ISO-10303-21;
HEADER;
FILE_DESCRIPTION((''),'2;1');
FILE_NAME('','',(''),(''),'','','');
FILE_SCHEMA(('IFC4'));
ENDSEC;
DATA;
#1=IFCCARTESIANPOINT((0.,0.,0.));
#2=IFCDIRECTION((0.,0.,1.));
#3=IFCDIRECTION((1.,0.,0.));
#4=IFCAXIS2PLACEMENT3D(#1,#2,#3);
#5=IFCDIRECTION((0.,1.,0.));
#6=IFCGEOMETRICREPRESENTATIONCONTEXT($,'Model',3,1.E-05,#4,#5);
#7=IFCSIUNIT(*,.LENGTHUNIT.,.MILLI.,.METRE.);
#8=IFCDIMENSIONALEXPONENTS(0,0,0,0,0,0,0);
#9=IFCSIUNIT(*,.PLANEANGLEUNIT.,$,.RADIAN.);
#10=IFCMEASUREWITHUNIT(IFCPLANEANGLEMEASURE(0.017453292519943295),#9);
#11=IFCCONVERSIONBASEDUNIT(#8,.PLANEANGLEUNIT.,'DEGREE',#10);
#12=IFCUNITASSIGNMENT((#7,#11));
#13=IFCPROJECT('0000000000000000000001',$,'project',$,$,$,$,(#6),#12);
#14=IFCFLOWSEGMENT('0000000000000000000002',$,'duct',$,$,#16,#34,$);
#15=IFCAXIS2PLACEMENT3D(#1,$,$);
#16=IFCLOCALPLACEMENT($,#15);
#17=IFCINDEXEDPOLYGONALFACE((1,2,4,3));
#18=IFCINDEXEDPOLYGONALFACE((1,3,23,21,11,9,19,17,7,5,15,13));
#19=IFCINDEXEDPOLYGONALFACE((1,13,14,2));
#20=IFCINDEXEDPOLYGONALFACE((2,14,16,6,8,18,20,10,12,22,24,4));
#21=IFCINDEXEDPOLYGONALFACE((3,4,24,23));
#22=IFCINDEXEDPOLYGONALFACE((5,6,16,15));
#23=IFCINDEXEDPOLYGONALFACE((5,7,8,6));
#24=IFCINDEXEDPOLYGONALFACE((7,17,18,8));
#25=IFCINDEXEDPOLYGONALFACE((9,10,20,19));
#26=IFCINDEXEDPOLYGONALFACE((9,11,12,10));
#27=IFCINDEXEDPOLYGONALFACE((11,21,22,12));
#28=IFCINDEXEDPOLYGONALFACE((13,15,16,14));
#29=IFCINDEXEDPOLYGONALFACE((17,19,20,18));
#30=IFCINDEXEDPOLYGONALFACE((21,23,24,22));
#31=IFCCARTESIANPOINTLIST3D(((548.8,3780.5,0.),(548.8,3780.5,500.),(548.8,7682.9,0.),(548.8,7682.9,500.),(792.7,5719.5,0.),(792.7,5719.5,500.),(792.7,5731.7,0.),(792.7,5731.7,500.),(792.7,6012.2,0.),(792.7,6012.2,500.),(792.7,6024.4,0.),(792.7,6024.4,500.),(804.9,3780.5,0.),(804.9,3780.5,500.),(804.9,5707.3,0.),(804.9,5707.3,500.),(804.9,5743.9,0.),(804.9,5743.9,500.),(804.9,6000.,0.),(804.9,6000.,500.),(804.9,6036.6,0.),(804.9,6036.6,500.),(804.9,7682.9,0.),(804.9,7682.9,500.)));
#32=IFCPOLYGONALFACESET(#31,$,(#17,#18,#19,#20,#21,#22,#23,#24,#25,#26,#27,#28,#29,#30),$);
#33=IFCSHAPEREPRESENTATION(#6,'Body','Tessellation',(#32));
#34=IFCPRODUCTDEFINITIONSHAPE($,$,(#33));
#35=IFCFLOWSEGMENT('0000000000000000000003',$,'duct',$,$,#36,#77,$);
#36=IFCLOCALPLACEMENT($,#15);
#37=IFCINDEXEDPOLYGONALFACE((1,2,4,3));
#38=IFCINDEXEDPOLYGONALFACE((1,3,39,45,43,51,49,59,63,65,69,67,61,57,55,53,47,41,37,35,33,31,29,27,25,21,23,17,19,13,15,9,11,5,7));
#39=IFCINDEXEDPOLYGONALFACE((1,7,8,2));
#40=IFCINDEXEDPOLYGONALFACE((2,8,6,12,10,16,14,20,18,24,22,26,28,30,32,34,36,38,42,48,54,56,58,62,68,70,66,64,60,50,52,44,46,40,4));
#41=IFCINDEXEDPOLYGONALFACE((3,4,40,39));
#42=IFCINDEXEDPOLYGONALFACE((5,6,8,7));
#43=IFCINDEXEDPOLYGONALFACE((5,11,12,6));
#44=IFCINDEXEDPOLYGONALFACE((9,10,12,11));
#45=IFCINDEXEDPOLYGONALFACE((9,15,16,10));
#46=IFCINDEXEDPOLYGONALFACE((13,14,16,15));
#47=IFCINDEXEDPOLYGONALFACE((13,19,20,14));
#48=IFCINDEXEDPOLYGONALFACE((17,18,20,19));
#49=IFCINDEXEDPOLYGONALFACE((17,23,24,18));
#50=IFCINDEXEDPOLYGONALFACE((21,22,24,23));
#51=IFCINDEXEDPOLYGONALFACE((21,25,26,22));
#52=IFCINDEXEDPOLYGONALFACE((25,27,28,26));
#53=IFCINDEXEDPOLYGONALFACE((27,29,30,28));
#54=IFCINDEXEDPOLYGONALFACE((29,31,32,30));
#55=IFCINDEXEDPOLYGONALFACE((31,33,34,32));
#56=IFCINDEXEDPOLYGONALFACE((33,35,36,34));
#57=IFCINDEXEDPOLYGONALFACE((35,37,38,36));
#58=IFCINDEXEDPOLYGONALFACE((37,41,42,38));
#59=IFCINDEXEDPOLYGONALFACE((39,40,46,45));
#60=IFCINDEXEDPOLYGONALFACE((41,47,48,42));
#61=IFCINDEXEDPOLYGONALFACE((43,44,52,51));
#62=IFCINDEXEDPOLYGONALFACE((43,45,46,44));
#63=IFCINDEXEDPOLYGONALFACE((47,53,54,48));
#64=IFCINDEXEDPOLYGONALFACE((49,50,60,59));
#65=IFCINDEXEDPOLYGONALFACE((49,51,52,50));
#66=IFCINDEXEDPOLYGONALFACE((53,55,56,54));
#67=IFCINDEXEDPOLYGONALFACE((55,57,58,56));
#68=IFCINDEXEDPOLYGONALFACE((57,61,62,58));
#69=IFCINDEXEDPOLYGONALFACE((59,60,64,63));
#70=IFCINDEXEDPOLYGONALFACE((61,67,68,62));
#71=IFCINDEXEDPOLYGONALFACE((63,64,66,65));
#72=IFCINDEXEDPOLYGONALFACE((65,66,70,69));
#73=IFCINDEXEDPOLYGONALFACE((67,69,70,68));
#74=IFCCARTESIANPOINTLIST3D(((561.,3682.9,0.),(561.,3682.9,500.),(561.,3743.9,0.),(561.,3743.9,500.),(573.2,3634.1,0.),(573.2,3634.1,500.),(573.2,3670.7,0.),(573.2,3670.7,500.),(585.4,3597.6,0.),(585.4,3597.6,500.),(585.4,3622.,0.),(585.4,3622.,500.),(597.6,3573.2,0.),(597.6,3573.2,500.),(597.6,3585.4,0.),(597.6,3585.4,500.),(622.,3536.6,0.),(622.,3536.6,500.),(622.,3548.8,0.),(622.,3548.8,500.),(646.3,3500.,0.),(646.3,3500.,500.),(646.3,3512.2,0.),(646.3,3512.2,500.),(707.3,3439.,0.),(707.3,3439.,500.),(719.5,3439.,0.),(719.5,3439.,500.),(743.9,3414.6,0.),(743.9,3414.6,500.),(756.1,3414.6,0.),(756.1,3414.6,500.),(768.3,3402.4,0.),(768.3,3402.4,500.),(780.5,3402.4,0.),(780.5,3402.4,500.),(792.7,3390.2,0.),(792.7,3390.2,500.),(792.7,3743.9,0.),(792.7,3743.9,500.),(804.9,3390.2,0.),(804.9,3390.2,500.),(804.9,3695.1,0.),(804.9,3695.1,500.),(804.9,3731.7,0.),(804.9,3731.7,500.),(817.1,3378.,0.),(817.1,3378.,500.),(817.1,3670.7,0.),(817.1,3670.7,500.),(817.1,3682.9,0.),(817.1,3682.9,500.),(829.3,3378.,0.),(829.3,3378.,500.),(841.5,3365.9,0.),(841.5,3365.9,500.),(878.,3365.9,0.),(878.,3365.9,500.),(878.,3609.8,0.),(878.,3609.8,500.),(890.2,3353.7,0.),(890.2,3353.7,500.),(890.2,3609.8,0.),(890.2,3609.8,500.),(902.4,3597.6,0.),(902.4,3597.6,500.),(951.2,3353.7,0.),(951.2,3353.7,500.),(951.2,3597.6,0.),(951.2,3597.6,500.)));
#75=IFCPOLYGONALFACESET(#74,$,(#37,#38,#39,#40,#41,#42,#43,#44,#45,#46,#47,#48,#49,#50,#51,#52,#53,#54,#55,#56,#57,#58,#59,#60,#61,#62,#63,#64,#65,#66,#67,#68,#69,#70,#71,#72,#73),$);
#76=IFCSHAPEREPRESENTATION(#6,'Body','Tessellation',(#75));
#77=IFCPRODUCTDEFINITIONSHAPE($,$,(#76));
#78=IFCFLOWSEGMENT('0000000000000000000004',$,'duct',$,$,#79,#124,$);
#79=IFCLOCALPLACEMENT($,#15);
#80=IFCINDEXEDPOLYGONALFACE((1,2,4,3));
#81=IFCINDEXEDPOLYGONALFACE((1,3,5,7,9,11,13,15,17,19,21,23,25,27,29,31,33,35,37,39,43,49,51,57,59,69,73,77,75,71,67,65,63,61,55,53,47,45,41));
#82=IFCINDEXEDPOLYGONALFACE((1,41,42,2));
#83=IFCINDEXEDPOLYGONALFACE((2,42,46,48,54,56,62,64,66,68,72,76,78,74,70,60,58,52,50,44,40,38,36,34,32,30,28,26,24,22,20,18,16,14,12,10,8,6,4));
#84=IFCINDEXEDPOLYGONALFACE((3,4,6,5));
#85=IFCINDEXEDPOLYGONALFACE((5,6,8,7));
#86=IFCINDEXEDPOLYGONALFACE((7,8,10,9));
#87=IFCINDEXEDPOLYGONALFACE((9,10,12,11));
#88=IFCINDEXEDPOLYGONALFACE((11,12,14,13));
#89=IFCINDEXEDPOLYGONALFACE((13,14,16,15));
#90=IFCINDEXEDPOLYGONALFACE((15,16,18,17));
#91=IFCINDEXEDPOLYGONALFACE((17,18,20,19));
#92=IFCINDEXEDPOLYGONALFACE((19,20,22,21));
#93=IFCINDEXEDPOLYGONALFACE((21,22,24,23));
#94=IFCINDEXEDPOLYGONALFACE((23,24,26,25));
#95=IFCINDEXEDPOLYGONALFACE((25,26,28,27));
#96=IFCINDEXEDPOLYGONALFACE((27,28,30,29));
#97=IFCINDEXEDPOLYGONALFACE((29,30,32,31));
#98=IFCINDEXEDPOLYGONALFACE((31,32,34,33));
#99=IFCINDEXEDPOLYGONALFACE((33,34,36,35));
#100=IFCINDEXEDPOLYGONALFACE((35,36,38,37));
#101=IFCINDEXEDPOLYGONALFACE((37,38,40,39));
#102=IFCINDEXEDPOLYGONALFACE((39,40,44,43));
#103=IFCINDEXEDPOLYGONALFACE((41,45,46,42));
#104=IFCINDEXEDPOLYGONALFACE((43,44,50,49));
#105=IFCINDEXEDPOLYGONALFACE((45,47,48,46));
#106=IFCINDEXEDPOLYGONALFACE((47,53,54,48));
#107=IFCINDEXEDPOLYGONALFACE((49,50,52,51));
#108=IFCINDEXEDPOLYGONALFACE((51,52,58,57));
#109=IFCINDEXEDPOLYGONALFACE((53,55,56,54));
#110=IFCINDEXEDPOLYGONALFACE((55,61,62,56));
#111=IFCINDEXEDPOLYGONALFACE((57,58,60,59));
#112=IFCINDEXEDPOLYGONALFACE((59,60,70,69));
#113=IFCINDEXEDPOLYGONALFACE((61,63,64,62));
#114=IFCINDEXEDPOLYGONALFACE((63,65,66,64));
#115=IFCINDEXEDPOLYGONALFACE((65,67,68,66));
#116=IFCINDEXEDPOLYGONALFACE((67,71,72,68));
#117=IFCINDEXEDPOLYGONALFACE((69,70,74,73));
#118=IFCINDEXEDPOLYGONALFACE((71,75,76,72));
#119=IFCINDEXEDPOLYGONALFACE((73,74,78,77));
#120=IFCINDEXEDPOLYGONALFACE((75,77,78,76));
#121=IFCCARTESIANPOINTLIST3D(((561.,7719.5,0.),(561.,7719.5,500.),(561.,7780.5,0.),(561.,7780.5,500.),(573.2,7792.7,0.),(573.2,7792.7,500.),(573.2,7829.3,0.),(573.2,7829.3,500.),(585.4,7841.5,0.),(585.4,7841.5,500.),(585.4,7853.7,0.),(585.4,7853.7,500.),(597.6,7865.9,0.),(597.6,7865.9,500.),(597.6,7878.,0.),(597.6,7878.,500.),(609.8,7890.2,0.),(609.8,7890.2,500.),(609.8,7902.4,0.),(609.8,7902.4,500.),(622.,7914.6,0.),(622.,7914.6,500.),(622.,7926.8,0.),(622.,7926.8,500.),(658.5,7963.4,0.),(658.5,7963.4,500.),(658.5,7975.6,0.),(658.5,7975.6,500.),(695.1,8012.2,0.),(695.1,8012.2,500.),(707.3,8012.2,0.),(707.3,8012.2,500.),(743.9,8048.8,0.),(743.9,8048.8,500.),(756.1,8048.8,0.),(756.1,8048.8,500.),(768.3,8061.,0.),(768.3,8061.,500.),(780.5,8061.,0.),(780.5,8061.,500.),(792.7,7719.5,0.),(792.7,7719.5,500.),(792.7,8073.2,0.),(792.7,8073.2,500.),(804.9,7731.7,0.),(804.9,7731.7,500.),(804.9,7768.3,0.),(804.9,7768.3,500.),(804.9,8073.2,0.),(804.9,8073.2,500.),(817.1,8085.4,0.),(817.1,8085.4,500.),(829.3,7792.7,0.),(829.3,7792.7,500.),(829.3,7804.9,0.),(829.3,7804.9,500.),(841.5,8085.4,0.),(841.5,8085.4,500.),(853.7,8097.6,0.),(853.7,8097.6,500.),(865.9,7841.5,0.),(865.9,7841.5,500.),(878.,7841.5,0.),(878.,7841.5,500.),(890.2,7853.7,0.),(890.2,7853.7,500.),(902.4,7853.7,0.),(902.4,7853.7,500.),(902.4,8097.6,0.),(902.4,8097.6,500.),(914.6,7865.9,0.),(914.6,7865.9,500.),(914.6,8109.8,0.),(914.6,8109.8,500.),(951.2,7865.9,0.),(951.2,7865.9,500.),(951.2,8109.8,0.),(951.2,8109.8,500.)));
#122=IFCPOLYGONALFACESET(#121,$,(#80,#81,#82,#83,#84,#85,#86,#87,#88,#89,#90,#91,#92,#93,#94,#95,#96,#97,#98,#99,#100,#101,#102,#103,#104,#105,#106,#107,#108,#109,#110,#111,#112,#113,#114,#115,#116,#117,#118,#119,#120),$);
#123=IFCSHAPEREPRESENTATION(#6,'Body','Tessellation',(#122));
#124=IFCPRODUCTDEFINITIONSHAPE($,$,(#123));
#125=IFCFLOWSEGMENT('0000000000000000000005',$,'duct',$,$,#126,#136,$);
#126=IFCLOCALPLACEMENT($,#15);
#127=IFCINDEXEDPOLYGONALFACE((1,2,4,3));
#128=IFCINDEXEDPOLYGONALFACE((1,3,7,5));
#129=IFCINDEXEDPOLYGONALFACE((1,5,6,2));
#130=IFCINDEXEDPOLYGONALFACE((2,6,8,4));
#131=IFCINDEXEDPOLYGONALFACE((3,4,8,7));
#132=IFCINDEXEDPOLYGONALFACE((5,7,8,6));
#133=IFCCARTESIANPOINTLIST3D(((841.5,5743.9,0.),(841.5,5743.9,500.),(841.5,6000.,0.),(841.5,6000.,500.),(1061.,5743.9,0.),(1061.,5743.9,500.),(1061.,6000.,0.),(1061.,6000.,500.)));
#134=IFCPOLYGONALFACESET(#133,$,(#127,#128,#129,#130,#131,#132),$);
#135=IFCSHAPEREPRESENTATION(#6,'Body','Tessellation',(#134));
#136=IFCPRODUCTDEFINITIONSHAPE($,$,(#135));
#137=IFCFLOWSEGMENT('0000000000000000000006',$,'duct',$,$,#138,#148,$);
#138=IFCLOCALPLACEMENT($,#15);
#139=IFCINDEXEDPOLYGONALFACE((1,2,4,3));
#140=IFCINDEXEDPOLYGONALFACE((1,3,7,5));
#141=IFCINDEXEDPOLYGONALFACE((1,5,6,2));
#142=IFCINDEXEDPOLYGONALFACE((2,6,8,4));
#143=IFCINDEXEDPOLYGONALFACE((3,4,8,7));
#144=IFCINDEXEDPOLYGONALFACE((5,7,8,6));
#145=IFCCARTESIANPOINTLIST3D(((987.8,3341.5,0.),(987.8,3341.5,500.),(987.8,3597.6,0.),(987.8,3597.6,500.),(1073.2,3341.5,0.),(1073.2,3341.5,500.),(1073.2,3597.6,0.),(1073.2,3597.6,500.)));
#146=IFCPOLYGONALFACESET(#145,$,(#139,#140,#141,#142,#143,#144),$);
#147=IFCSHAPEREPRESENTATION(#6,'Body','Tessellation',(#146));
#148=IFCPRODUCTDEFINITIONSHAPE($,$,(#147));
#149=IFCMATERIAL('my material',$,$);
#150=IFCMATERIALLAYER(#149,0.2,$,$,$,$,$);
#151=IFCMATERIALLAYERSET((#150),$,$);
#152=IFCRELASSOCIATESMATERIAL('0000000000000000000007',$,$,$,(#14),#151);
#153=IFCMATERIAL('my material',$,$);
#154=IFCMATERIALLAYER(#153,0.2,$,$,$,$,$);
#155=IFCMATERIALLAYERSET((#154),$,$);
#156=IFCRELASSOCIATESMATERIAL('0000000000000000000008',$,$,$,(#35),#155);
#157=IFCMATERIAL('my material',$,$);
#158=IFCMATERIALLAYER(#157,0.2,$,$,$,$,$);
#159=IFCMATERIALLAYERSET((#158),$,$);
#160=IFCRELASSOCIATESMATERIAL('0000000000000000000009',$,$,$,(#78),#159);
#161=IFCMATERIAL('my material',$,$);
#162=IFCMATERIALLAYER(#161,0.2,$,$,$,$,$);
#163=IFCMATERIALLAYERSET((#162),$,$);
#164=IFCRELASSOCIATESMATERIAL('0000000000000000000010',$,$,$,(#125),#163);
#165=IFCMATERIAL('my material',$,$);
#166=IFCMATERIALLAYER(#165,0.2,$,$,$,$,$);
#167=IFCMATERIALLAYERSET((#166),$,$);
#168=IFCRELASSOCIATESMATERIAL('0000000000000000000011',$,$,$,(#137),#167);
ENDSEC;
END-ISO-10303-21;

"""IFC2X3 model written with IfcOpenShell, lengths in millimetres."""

from ifc_helpers import new_model, entity, si_unit, converted_unit, direction, origin_with_axes, place, context, project, polyline, outline, extrude, material, layer, layer_set, layer_usage, element, save


model = new_model("IFC2X3")

# Units and contexts
model_context = context("Model", 3, precision=1e-05, world=origin_with_axes(), true_north=direction((0.0, 1.0, 0.0)))
ifc_project = project(units=[si_unit("LENGTHUNIT", "METRE", prefix="MILLI"), converted_unit("PLANEANGLEUNIT", "DEGREE", entity("IfcPlaneAngleMeasure", 0.017453292519943295), si_unit("PLANEANGLEUNIT", "RADIAN"), dimensions=[0, 0, 0, 0, 0, 0, 0])], contexts=[model_context])

# Flow segments
ifc_material_1 = material(Name="my material")
ifc_layer_1 = layer(ifc_material_1, 0.2)
ifc_layer_set_1 = layer_set([ifc_layer_1])
ifc_layer_usage_1 = layer_usage(ifc_layer_set_1, "AXIS2", "POSITIVE", -0.1)
flow_segment_1_placement = place(None, origin_with_axes())
element("IfcFlowSegment", 1, at=flow_segment_1_placement, material=ifc_layer_usage_1, Name="duct", context=model_context, shape_type="SweptSolid", body=[
    extrude(outline(polyline([(548.8, 3780.5), (804.9, 3780.5), (804.9, 5707.3), (792.7, 5719.5), (792.7, 5731.7), (804.9, 5743.9), (804.9, 6000.0), (792.7, 6012.2), (792.7, 6024.4), (804.9, 6036.6), (804.9, 7682.9), (548.8, 7682.9), (548.8, 3780.5)])), origin_with_axes(), (0.0, 0.0, 1.0), 500.0),
])
ifc_material_2 = material(Name="my material")
ifc_layer_2 = layer(ifc_material_2, 0.2)
ifc_layer_set_2 = layer_set([ifc_layer_2])
ifc_layer_usage_2 = layer_usage(ifc_layer_set_2, "AXIS2", "POSITIVE", -0.1)
flow_segment_2_placement = place(None, origin_with_axes())
element("IfcFlowSegment", 2, at=flow_segment_2_placement, material=ifc_layer_usage_2, Name="duct", context=model_context, shape_type="SweptSolid", body=[
    extrude(outline(polyline([(561.0, 3682.9), (573.2, 3670.7), (573.2, 3634.1), (585.4, 3622.0), (585.4, 3597.6), (597.6, 3585.4), (597.6, 3573.2), (622.0, 3548.8), (622.0, 3536.6), (646.3, 3512.2), (646.3, 3500.0), (707.3, 3439.0), (719.5, 3439.0), (743.9, 3414.6), (756.1, 3414.6), (768.3, 3402.4), (780.5, 3402.4), (792.7, 3390.2), (804.9, 3390.2), (817.1, 3378.0), (829.3, 3378.0), (841.5, 3365.9), (878.0, 3365.9), (890.2, 3353.7), (951.2, 3353.7), (951.2, 3597.6), (902.4, 3597.6), (890.2, 3609.8), (878.0, 3609.8), (817.1, 3670.7), (817.1, 3682.9), (804.9, 3695.1), (804.9, 3731.7), (792.7, 3743.9), (561.0, 3743.9), (561.0, 3682.9)])), origin_with_axes(), (0.0, 0.0, 1.0), 500.0),
])
ifc_material_3 = material(Name="my material")
ifc_layer_3 = layer(ifc_material_3, 0.2)
ifc_layer_set_3 = layer_set([ifc_layer_3])
ifc_layer_usage_3 = layer_usage(ifc_layer_set_3, "AXIS2", "POSITIVE", -0.1)
flow_segment_3_placement = place(None, origin_with_axes())
element("IfcFlowSegment", 3, at=flow_segment_3_placement, material=ifc_layer_usage_3, Name="duct", context=model_context, shape_type="SweptSolid", body=[
    extrude(outline(polyline([(561.0, 7719.5), (792.7, 7719.5), (804.9, 7731.7), (804.9, 7768.3), (829.3, 7792.7), (829.3, 7804.9), (865.9, 7841.5), (878.0, 7841.5), (890.2, 7853.7), (902.4, 7853.7), (914.6, 7865.9), (951.2, 7865.9), (951.2, 8109.8), (914.6, 8109.8), (902.4, 8097.6), (853.7, 8097.6), (841.5, 8085.4), (817.1, 8085.4), (804.9, 8073.2), (792.7, 8073.2), (780.5, 8061.0), (768.3, 8061.0), (756.1, 8048.8), (743.9, 8048.8), (707.3, 8012.2), (695.1, 8012.2), (658.5, 7975.6), (658.5, 7963.4), (622.0, 7926.8), (622.0, 7914.6), (609.8, 7902.4), (609.8, 7890.2), (597.6, 7878.0), (597.6, 7865.9), (585.4, 7853.7), (585.4, 7841.5), (573.2, 7829.3), (573.2, 7792.7), (561.0, 7780.5), (561.0, 7719.5)])), origin_with_axes(), (0.0, 0.0, 1.0), 500.0),
])
ifc_material_4 = material(Name="my material")
ifc_layer_4 = layer(ifc_material_4, 0.2)
ifc_layer_set_4 = layer_set([ifc_layer_4])
ifc_layer_usage_4 = layer_usage(ifc_layer_set_4, "AXIS2", "POSITIVE", -0.1)
flow_segment_4_placement = place(None, origin_with_axes())
element("IfcFlowSegment", 4, at=flow_segment_4_placement, material=ifc_layer_usage_4, Name="duct", context=model_context, shape_type="SweptSolid", body=[
    extrude(outline(polyline([(841.5, 5743.9), (1061.0, 5743.9), (1061.0, 6000.0), (841.5, 6000.0), (841.5, 5743.9)])), origin_with_axes(), (0.0, 0.0, 1.0), 500.0),
])
ifc_material_5 = material(Name="my material")
ifc_layer_5 = layer(ifc_material_5, 0.2)
ifc_layer_set_5 = layer_set([ifc_layer_5])
ifc_layer_usage_5 = layer_usage(ifc_layer_set_5, "AXIS2", "POSITIVE", -0.1)
flow_segment_5_placement = place(None, origin_with_axes())
element("IfcFlowSegment", 5, at=flow_segment_5_placement, material=ifc_layer_usage_5, Name="duct", context=model_context, shape_type="SweptSolid", body=[
    extrude(outline(polyline([(987.8, 3341.5), (1073.2, 3341.5), (1073.2, 3597.6), (987.8, 3597.6), (987.8, 3341.5)])), origin_with_axes(), (0.0, 0.0, 1.0), 500.0),
])

save(model, "model.ifc")
